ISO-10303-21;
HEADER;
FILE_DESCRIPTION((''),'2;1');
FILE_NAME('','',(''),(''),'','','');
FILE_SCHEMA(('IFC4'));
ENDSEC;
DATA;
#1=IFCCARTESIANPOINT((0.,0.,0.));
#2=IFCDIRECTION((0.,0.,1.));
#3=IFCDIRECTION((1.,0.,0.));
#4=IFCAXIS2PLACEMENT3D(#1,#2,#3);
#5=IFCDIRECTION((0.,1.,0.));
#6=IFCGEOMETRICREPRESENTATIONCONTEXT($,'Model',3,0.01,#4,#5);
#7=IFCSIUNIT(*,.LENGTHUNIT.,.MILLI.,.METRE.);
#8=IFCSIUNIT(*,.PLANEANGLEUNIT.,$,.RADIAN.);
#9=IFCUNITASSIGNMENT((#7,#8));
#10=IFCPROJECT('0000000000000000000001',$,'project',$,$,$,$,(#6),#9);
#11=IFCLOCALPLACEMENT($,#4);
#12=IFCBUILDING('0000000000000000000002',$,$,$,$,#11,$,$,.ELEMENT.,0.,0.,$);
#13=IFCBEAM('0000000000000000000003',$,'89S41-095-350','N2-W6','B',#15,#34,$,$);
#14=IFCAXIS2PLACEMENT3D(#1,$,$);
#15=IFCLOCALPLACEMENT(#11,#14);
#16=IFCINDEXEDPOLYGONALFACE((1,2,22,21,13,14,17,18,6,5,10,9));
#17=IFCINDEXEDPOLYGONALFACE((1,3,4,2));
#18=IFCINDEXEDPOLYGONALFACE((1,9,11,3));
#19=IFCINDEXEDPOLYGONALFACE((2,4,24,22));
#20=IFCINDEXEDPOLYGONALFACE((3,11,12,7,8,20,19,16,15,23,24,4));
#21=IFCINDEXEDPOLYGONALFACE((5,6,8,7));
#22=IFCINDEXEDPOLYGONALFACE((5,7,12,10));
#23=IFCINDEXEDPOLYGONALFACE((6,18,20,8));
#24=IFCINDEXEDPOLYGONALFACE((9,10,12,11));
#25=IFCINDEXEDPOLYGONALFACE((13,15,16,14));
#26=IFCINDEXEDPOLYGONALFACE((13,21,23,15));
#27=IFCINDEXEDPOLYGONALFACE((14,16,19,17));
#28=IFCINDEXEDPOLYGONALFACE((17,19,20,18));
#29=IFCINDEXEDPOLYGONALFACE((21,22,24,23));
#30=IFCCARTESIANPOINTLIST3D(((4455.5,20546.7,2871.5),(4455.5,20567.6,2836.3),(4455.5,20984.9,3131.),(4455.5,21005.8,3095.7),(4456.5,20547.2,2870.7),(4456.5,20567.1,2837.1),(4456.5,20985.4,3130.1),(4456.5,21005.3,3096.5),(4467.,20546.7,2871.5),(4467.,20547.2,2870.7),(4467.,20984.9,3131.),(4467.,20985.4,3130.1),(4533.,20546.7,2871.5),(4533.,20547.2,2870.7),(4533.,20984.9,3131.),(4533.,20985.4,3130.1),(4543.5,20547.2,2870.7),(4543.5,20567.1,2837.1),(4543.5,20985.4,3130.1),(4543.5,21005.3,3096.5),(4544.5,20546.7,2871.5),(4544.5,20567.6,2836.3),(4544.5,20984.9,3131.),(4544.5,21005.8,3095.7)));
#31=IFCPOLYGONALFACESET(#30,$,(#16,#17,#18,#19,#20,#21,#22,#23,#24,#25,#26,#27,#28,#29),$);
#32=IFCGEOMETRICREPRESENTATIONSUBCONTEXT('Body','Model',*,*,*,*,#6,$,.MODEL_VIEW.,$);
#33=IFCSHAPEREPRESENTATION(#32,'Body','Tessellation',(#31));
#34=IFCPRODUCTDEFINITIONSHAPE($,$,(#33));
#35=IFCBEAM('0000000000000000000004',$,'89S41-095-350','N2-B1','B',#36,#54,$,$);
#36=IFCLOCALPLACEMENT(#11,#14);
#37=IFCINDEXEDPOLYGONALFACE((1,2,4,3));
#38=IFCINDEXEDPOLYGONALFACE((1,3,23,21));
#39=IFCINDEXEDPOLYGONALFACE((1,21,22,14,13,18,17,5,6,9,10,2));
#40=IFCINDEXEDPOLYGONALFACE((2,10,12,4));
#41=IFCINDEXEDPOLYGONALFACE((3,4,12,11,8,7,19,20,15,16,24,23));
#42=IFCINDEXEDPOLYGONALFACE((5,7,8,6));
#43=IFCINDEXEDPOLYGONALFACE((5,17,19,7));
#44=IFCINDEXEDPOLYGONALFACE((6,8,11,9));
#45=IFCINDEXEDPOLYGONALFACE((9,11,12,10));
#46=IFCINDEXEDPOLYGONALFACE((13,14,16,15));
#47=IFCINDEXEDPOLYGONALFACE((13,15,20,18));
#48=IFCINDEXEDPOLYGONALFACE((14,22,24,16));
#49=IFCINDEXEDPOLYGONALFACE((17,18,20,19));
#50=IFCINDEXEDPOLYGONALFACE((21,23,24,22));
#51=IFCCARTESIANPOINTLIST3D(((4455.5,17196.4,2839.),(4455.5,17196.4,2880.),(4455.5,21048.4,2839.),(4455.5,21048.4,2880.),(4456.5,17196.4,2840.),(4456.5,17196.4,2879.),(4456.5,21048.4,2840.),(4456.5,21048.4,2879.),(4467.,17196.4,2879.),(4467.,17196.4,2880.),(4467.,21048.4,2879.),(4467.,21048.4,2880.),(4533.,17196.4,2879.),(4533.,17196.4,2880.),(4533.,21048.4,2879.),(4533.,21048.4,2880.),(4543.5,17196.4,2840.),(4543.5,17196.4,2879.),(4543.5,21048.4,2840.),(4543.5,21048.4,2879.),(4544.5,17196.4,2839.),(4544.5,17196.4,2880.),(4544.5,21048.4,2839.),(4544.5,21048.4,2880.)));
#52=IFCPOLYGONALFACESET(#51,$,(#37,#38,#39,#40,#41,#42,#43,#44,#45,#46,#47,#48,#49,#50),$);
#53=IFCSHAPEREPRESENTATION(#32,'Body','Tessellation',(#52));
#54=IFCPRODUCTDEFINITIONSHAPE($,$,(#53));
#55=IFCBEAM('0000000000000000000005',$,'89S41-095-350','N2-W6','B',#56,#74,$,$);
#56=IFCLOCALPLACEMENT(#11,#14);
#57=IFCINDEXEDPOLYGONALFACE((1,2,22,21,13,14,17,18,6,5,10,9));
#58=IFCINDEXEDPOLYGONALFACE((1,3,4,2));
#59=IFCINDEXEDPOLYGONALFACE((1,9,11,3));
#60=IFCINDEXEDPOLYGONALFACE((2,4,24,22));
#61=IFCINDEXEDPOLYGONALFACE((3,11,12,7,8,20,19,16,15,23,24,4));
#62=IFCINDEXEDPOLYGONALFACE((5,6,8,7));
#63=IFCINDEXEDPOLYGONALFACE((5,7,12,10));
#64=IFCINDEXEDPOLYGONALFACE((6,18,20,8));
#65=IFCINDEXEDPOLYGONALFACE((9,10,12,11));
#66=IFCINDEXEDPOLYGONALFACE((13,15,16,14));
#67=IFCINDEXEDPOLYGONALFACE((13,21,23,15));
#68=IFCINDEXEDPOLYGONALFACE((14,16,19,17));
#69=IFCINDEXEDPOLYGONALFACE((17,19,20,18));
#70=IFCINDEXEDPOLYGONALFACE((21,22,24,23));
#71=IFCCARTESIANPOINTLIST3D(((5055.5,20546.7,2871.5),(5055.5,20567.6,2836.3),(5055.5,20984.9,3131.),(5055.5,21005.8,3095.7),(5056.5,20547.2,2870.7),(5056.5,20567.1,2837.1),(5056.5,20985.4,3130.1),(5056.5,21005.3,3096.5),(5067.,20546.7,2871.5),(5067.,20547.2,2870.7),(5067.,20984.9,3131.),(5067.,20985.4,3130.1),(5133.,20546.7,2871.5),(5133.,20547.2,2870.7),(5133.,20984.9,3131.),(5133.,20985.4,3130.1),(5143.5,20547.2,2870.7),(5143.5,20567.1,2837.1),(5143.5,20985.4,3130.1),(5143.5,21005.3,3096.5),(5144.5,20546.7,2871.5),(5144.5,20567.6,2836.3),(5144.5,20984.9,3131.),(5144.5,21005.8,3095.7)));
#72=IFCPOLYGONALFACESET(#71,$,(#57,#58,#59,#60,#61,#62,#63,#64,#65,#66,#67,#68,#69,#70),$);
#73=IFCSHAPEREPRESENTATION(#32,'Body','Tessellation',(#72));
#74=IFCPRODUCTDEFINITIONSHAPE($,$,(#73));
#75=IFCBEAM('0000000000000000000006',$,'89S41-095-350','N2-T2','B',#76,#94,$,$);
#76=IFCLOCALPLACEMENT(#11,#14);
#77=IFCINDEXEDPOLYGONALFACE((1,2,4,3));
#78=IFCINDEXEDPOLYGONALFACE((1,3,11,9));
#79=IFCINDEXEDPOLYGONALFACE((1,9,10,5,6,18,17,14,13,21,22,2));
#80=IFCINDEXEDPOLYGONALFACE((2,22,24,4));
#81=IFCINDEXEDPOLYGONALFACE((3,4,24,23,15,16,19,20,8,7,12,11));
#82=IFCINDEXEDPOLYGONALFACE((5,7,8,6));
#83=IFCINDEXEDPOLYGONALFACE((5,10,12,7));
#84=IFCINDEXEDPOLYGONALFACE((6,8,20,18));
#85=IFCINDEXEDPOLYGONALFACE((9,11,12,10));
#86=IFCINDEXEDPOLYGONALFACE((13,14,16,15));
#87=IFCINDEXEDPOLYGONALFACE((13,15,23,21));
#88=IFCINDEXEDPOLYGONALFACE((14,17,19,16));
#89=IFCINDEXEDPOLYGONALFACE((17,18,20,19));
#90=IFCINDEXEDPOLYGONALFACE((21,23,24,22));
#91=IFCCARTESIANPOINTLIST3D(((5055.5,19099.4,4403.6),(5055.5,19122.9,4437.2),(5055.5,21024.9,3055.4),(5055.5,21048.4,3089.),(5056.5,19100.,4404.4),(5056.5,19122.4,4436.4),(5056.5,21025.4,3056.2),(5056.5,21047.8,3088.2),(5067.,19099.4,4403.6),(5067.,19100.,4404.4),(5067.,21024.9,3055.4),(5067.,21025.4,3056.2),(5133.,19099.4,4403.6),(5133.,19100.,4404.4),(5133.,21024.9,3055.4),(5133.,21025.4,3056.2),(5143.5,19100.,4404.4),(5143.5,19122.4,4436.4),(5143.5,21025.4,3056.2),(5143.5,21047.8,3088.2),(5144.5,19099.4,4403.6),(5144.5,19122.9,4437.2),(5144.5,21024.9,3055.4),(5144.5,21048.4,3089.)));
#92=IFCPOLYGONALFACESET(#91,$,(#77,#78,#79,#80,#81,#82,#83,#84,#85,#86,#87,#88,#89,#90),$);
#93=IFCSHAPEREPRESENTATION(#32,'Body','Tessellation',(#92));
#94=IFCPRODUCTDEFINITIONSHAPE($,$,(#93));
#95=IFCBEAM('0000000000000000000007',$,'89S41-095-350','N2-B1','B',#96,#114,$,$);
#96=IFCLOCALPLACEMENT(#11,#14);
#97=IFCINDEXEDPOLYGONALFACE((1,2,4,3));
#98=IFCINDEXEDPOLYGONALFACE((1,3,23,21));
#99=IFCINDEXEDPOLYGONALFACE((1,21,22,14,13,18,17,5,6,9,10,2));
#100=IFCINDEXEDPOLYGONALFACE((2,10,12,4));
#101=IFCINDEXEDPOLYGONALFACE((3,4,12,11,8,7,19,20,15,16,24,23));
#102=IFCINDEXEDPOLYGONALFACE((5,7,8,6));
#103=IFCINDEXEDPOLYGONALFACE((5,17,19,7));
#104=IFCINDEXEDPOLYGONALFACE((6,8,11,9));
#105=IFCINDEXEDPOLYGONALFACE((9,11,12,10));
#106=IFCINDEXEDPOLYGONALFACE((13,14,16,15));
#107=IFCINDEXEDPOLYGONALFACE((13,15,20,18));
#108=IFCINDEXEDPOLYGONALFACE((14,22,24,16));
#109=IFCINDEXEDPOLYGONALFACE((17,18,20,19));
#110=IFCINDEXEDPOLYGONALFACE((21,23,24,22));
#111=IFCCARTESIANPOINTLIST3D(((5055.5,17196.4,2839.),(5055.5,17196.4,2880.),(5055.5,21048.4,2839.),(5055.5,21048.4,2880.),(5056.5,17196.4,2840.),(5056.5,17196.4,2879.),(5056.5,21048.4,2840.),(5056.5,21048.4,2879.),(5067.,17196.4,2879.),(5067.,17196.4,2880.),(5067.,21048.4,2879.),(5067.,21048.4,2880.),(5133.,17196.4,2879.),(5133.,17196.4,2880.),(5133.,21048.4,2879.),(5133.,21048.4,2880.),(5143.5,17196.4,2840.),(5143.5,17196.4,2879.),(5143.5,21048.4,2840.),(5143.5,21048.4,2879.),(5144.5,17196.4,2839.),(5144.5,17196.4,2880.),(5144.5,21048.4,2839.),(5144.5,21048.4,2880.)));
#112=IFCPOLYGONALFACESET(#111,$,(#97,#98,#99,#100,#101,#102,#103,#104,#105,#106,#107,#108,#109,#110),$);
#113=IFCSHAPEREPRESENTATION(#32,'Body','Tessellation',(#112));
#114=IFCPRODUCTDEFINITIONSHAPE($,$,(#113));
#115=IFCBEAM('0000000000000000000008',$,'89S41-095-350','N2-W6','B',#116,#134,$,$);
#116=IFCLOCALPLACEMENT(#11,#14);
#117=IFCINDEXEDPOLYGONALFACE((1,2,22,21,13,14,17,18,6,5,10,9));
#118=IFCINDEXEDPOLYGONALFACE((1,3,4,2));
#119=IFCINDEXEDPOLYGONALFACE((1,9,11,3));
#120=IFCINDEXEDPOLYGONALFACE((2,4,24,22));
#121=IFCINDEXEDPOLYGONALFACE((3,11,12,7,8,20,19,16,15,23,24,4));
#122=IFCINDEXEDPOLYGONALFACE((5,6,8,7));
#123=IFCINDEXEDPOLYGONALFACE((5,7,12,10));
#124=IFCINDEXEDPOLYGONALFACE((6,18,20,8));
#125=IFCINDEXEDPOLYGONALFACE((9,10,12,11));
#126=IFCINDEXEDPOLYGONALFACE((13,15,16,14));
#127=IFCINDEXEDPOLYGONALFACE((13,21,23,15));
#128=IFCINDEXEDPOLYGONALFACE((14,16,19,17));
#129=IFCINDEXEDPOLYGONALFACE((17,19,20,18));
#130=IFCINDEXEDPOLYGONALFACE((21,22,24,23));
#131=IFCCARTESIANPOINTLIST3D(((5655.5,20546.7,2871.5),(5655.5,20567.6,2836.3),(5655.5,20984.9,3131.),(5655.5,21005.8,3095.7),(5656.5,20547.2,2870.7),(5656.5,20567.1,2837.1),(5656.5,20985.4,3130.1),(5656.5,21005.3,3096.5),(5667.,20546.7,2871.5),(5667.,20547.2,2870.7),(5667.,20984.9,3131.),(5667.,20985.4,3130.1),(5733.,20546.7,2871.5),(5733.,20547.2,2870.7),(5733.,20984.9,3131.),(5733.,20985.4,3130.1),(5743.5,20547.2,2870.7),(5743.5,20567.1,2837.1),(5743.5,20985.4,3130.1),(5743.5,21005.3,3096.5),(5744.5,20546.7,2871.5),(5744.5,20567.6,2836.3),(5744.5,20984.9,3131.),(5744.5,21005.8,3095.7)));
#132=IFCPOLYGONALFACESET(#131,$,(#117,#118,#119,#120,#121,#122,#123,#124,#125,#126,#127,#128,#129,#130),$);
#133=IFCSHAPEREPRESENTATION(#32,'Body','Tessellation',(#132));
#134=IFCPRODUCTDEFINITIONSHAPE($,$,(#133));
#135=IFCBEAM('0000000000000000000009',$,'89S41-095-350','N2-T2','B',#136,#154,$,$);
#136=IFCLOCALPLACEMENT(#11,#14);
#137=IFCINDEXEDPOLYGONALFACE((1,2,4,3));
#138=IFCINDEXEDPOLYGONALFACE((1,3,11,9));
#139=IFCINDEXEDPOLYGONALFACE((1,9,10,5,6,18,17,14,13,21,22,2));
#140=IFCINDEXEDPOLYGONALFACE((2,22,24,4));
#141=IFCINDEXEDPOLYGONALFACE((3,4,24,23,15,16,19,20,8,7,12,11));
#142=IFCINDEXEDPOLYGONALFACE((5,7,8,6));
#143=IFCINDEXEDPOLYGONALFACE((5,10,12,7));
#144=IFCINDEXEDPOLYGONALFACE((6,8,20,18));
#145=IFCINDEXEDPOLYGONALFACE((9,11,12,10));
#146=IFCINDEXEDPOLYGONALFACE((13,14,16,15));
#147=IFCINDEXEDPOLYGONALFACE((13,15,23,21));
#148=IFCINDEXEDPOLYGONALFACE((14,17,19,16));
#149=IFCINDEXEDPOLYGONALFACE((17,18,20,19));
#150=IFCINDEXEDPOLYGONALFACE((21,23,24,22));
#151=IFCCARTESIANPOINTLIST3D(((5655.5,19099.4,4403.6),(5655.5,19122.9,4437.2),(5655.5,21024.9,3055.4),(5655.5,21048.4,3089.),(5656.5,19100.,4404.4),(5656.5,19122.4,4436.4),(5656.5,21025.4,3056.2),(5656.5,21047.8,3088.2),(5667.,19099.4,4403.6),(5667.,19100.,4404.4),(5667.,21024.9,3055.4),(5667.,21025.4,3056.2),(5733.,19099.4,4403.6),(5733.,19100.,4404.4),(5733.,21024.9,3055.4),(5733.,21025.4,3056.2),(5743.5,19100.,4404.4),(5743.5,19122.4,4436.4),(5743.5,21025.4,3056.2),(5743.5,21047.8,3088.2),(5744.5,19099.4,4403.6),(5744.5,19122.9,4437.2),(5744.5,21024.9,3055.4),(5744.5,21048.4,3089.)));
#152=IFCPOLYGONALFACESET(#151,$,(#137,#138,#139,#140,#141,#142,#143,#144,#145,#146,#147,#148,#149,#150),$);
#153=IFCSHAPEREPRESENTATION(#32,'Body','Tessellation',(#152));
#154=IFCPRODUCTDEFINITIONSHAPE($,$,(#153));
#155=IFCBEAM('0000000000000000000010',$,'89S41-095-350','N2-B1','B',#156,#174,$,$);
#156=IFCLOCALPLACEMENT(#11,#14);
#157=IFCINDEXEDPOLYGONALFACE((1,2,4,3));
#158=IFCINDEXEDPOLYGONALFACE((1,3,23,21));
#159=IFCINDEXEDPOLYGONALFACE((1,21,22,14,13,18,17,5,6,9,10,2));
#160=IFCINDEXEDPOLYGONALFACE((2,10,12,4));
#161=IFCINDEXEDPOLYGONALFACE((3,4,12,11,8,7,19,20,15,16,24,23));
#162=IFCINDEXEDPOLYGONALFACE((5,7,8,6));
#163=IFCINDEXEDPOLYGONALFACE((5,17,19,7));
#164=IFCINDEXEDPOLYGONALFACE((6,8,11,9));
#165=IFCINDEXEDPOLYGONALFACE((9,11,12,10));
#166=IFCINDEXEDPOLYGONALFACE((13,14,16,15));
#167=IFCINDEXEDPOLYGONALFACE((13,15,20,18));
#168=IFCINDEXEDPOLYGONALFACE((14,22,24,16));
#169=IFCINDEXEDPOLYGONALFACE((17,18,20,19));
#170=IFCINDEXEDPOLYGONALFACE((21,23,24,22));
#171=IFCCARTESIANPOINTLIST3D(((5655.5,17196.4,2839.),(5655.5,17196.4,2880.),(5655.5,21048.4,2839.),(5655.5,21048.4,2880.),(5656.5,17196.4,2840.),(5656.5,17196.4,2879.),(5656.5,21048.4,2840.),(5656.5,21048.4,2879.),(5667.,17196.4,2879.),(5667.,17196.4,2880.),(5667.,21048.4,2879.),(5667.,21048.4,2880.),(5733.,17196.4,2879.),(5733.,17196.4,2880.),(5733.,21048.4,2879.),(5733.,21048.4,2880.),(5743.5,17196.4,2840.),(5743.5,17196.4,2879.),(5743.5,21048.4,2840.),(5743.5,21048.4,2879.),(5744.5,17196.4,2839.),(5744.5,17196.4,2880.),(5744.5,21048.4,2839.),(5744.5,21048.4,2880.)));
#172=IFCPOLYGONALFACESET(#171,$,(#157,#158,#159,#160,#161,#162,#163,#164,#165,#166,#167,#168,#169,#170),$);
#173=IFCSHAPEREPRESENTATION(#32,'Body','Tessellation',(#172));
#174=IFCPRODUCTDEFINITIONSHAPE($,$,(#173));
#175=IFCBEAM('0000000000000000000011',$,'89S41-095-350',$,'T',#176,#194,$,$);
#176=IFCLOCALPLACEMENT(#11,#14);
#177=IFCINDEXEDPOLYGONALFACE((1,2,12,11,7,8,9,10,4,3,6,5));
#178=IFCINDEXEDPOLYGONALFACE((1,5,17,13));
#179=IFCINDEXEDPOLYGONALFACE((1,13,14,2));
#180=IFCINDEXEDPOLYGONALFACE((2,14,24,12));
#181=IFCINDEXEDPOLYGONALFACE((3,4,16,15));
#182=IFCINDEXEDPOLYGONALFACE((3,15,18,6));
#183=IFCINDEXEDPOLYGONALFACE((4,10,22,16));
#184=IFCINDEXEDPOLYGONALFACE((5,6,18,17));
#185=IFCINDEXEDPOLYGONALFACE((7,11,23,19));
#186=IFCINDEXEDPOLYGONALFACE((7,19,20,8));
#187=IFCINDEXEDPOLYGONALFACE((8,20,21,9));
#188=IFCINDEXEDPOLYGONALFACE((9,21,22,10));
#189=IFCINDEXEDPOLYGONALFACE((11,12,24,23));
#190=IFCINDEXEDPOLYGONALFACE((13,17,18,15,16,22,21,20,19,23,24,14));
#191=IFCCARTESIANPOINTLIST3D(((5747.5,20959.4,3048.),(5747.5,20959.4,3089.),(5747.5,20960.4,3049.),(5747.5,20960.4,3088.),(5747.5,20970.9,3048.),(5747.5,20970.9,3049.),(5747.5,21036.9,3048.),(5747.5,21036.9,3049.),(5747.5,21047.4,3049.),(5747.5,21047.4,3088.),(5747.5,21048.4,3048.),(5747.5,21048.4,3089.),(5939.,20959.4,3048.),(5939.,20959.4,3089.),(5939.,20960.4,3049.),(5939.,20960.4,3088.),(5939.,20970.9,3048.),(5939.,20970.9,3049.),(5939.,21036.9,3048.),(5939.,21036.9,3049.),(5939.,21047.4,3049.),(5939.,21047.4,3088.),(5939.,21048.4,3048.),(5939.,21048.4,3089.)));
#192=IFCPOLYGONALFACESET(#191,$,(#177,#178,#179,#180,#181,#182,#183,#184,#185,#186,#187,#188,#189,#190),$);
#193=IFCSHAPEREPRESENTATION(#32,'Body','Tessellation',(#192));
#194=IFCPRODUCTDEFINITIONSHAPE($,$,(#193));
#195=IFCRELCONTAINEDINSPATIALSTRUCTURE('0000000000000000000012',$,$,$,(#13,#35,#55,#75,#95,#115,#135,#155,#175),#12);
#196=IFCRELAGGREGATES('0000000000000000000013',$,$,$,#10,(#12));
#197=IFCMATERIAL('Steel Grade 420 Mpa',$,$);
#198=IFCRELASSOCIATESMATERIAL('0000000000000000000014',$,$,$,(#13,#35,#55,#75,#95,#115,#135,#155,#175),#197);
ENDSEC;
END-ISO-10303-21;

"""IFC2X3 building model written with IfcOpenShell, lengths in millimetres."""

from ifc_helpers import new_model, si_unit, direction, frame, origin, origin_with_axes, origin_2d_with_axis, place, context, subcontext, project, spatial, c_section, extrude, source, transform, mapped, material, element, save


model = new_model("IFC2X3")

# Units and contexts
model_context = context("Model", 3, precision=0.01, world=origin_with_axes(), true_north=direction((0.0, 1.0, 0.0)))
body_context = subcontext(model_context, "Body", "Model", "MODEL_VIEW")
ifc_project = project(units=[si_unit("LENGTHUNIT", "METRE", prefix="MILLI"), si_unit("PLANEANGLEUNIT", "RADIAN")], contexts=[model_context])

# Building
building_placement = place(None, origin_with_axes())
building = spatial("IfcBuilding", under=ifc_project, at=building_placement, CompositionType="ELEMENT", ElevationOfRefHeight=0.0, ElevationOfTerrain=0.0)

# Shared definitions
ifc_material = material(Name="Steel Grade 420 Mpa")

# Beams
shared_shape_1 = source(origin(), body_context, "Body", "SweptSolid", [
    extrude(c_section(Depth=89.0, Width=41.0, WallThickness=1.0, Girth=11.5, at=origin_2d_with_axis()), origin_with_axes(), (0.0, 0.0, 1.0), 509.2),
])
beam_1_placement = place(None, frame((4500.0, 20995.4, 3113.3), z_axis=(0.0, -0.860497, -0.509455), x_axis=(0.0, -0.509455, 0.860497)))
element("IfcBeam", 1, at=beam_1_placement, inside=building, material=ifc_material, Name="89S41-095-350", Description="N2-W6", ObjectType="B", context=body_context, shape_type="MappedRepresentation", body=[
    mapped(shared_shape_1, transform((0.0, 0.0, 0.0), scale=1.0)),
])
shared_shape_2 = source(origin(), body_context, "Body", "SweptSolid", [
    extrude(c_section(Depth=89.0, Width=41.0, WallThickness=1.0, Girth=11.5, at=origin_2d_with_axis()), origin_with_axes(), (0.0, 0.0, 1.0), 3852.0),
])
beam_2_placement = place(None, frame((4500.0, 21048.4, 2859.5), z_axis=(0.0, -1.0, 0.0), x_axis=(0.0, 0.0, 1.0)))
element("IfcBeam", 2, at=beam_2_placement, inside=building, material=ifc_material, Name="89S41-095-350", Description="N2-B1", ObjectType="B", context=body_context, shape_type="MappedRepresentation", body=[
    mapped(shared_shape_2, transform((0.0, 0.0, 0.0), scale=1.0)),
])
shared_shape_3 = source(origin(), body_context, "Body", "SweptSolid", [
    extrude(c_section(Depth=89.0, Width=41.0, WallThickness=1.0, Girth=11.5, at=origin_2d_with_axis()), origin_with_axes(), (0.0, 0.0, 1.0), 509.2),
])
beam_3_placement = place(None, frame((5100.0, 20995.4, 3113.3), z_axis=(0.0, -0.860497, -0.509455), x_axis=(0.0, -0.509455, 0.860497)))
element("IfcBeam", 3, at=beam_3_placement, inside=building, material=ifc_material, Name="89S41-095-350", Description="N2-W6", ObjectType="B", context=body_context, shape_type="MappedRepresentation", body=[
    mapped(shared_shape_3, transform((0.0, 0.0, 0.0), scale=1.0)),
])
shared_shape_4 = source(origin(), body_context, "Body", "SweptSolid", [
    extrude(c_section(Depth=89.0, Width=41.0, WallThickness=1.0, Girth=11.5, at=origin_2d_with_axis()), origin_with_axes(), (0.0, 0.0, 1.0), 2350.5),
])
beam_4_placement = place(None, frame((5100.0, 19111.2, 4420.4), z_axis=(0.0, 0.819152, -0.573576), x_axis=(0.0, -0.573576, -0.819152)))
element("IfcBeam", 4, at=beam_4_placement, inside=building, material=ifc_material, Name="89S41-095-350", Description="N2-T2", ObjectType="B", context=body_context, shape_type="MappedRepresentation", body=[
    mapped(shared_shape_4, transform((0.0, 0.0, 0.0), scale=1.0)),
])
shared_shape_5 = source(origin(), body_context, "Body", "SweptSolid", [
    extrude(c_section(Depth=89.0, Width=41.0, WallThickness=1.0, Girth=11.5, at=origin_2d_with_axis()), origin_with_axes(), (0.0, 0.0, 1.0), 3852.0),
])
beam_5_placement = place(None, frame((5100.0, 21048.4, 2859.5), z_axis=(0.0, -1.0, 0.0), x_axis=(0.0, 0.0, 1.0)))
element("IfcBeam", 5, at=beam_5_placement, inside=building, material=ifc_material, Name="89S41-095-350", Description="N2-B1", ObjectType="B", context=body_context, shape_type="MappedRepresentation", body=[
    mapped(shared_shape_5, transform((0.0, 0.0, 0.0), scale=1.0)),
])
shared_shape_6 = source(origin(), body_context, "Body", "SweptSolid", [
    extrude(c_section(Depth=89.0, Width=41.0, WallThickness=1.0, Girth=11.5, at=origin_2d_with_axis()), origin_with_axes(), (0.0, 0.0, 1.0), 509.2),
])
beam_6_placement = place(None, frame((5700.0, 20995.4, 3113.3), z_axis=(0.0, -0.860497, -0.509455), x_axis=(0.0, -0.509455, 0.860497)))
element("IfcBeam", 6, at=beam_6_placement, inside=building, material=ifc_material, Name="89S41-095-350", Description="N2-W6", ObjectType="B", context=body_context, shape_type="MappedRepresentation", body=[
    mapped(shared_shape_6, transform((0.0, 0.0, 0.0), scale=1.0)),
])
shared_shape_7 = source(origin(), body_context, "Body", "SweptSolid", [
    extrude(c_section(Depth=89.0, Width=41.0, WallThickness=1.0, Girth=11.5, at=origin_2d_with_axis()), origin_with_axes(), (0.0, 0.0, 1.0), 2350.5),
])
beam_7_placement = place(None, frame((5700.0, 19111.2, 4420.4), z_axis=(0.0, 0.819152, -0.573576), x_axis=(0.0, -0.573576, -0.819152)))
element("IfcBeam", 7, at=beam_7_placement, inside=building, material=ifc_material, Name="89S41-095-350", Description="N2-T2", ObjectType="B", context=body_context, shape_type="MappedRepresentation", body=[
    mapped(shared_shape_7, transform((0.0, 0.0, 0.0), scale=1.0)),
])
shared_shape_8 = source(origin(), body_context, "Body", "SweptSolid", [
    extrude(c_section(Depth=89.0, Width=41.0, WallThickness=1.0, Girth=11.5, at=origin_2d_with_axis()), origin_with_axes(), (0.0, 0.0, 1.0), 3852.0),
])
beam_8_placement = place(None, frame((5700.0, 21048.4, 2859.5), z_axis=(0.0, -1.0, 0.0), x_axis=(0.0, 0.0, 1.0)))
element("IfcBeam", 8, at=beam_8_placement, inside=building, material=ifc_material, Name="89S41-095-350", Description="N2-B1", ObjectType="B", context=body_context, shape_type="MappedRepresentation", body=[
    mapped(shared_shape_8, transform((0.0, 0.0, 0.0), scale=1.0)),
])
shared_shape_9 = source(origin(), body_context, "Body", "SweptSolid", [
    extrude(c_section(Depth=89.0, Width=41.0, WallThickness=1.0, Girth=11.5, at=origin_2d_with_axis()), origin_with_axes(), (0.0, 0.0, 1.0), 191.5),
])
beam_9_placement = place(None, frame((5939.0, 21003.9, 3068.5), z_axis=(-1.0, 0.0, 0.0), x_axis=(0.0, 0.0, -1.0)))
element("IfcBeam", 9, at=beam_9_placement, inside=building, material=ifc_material, Name="89S41-095-350", ObjectType="T", context=body_context, shape_type="MappedRepresentation", body=[
    mapped(shared_shape_9, transform((0.0, 0.0, 0.0), scale=1.0)),
])

save(model, "model.ifc")
